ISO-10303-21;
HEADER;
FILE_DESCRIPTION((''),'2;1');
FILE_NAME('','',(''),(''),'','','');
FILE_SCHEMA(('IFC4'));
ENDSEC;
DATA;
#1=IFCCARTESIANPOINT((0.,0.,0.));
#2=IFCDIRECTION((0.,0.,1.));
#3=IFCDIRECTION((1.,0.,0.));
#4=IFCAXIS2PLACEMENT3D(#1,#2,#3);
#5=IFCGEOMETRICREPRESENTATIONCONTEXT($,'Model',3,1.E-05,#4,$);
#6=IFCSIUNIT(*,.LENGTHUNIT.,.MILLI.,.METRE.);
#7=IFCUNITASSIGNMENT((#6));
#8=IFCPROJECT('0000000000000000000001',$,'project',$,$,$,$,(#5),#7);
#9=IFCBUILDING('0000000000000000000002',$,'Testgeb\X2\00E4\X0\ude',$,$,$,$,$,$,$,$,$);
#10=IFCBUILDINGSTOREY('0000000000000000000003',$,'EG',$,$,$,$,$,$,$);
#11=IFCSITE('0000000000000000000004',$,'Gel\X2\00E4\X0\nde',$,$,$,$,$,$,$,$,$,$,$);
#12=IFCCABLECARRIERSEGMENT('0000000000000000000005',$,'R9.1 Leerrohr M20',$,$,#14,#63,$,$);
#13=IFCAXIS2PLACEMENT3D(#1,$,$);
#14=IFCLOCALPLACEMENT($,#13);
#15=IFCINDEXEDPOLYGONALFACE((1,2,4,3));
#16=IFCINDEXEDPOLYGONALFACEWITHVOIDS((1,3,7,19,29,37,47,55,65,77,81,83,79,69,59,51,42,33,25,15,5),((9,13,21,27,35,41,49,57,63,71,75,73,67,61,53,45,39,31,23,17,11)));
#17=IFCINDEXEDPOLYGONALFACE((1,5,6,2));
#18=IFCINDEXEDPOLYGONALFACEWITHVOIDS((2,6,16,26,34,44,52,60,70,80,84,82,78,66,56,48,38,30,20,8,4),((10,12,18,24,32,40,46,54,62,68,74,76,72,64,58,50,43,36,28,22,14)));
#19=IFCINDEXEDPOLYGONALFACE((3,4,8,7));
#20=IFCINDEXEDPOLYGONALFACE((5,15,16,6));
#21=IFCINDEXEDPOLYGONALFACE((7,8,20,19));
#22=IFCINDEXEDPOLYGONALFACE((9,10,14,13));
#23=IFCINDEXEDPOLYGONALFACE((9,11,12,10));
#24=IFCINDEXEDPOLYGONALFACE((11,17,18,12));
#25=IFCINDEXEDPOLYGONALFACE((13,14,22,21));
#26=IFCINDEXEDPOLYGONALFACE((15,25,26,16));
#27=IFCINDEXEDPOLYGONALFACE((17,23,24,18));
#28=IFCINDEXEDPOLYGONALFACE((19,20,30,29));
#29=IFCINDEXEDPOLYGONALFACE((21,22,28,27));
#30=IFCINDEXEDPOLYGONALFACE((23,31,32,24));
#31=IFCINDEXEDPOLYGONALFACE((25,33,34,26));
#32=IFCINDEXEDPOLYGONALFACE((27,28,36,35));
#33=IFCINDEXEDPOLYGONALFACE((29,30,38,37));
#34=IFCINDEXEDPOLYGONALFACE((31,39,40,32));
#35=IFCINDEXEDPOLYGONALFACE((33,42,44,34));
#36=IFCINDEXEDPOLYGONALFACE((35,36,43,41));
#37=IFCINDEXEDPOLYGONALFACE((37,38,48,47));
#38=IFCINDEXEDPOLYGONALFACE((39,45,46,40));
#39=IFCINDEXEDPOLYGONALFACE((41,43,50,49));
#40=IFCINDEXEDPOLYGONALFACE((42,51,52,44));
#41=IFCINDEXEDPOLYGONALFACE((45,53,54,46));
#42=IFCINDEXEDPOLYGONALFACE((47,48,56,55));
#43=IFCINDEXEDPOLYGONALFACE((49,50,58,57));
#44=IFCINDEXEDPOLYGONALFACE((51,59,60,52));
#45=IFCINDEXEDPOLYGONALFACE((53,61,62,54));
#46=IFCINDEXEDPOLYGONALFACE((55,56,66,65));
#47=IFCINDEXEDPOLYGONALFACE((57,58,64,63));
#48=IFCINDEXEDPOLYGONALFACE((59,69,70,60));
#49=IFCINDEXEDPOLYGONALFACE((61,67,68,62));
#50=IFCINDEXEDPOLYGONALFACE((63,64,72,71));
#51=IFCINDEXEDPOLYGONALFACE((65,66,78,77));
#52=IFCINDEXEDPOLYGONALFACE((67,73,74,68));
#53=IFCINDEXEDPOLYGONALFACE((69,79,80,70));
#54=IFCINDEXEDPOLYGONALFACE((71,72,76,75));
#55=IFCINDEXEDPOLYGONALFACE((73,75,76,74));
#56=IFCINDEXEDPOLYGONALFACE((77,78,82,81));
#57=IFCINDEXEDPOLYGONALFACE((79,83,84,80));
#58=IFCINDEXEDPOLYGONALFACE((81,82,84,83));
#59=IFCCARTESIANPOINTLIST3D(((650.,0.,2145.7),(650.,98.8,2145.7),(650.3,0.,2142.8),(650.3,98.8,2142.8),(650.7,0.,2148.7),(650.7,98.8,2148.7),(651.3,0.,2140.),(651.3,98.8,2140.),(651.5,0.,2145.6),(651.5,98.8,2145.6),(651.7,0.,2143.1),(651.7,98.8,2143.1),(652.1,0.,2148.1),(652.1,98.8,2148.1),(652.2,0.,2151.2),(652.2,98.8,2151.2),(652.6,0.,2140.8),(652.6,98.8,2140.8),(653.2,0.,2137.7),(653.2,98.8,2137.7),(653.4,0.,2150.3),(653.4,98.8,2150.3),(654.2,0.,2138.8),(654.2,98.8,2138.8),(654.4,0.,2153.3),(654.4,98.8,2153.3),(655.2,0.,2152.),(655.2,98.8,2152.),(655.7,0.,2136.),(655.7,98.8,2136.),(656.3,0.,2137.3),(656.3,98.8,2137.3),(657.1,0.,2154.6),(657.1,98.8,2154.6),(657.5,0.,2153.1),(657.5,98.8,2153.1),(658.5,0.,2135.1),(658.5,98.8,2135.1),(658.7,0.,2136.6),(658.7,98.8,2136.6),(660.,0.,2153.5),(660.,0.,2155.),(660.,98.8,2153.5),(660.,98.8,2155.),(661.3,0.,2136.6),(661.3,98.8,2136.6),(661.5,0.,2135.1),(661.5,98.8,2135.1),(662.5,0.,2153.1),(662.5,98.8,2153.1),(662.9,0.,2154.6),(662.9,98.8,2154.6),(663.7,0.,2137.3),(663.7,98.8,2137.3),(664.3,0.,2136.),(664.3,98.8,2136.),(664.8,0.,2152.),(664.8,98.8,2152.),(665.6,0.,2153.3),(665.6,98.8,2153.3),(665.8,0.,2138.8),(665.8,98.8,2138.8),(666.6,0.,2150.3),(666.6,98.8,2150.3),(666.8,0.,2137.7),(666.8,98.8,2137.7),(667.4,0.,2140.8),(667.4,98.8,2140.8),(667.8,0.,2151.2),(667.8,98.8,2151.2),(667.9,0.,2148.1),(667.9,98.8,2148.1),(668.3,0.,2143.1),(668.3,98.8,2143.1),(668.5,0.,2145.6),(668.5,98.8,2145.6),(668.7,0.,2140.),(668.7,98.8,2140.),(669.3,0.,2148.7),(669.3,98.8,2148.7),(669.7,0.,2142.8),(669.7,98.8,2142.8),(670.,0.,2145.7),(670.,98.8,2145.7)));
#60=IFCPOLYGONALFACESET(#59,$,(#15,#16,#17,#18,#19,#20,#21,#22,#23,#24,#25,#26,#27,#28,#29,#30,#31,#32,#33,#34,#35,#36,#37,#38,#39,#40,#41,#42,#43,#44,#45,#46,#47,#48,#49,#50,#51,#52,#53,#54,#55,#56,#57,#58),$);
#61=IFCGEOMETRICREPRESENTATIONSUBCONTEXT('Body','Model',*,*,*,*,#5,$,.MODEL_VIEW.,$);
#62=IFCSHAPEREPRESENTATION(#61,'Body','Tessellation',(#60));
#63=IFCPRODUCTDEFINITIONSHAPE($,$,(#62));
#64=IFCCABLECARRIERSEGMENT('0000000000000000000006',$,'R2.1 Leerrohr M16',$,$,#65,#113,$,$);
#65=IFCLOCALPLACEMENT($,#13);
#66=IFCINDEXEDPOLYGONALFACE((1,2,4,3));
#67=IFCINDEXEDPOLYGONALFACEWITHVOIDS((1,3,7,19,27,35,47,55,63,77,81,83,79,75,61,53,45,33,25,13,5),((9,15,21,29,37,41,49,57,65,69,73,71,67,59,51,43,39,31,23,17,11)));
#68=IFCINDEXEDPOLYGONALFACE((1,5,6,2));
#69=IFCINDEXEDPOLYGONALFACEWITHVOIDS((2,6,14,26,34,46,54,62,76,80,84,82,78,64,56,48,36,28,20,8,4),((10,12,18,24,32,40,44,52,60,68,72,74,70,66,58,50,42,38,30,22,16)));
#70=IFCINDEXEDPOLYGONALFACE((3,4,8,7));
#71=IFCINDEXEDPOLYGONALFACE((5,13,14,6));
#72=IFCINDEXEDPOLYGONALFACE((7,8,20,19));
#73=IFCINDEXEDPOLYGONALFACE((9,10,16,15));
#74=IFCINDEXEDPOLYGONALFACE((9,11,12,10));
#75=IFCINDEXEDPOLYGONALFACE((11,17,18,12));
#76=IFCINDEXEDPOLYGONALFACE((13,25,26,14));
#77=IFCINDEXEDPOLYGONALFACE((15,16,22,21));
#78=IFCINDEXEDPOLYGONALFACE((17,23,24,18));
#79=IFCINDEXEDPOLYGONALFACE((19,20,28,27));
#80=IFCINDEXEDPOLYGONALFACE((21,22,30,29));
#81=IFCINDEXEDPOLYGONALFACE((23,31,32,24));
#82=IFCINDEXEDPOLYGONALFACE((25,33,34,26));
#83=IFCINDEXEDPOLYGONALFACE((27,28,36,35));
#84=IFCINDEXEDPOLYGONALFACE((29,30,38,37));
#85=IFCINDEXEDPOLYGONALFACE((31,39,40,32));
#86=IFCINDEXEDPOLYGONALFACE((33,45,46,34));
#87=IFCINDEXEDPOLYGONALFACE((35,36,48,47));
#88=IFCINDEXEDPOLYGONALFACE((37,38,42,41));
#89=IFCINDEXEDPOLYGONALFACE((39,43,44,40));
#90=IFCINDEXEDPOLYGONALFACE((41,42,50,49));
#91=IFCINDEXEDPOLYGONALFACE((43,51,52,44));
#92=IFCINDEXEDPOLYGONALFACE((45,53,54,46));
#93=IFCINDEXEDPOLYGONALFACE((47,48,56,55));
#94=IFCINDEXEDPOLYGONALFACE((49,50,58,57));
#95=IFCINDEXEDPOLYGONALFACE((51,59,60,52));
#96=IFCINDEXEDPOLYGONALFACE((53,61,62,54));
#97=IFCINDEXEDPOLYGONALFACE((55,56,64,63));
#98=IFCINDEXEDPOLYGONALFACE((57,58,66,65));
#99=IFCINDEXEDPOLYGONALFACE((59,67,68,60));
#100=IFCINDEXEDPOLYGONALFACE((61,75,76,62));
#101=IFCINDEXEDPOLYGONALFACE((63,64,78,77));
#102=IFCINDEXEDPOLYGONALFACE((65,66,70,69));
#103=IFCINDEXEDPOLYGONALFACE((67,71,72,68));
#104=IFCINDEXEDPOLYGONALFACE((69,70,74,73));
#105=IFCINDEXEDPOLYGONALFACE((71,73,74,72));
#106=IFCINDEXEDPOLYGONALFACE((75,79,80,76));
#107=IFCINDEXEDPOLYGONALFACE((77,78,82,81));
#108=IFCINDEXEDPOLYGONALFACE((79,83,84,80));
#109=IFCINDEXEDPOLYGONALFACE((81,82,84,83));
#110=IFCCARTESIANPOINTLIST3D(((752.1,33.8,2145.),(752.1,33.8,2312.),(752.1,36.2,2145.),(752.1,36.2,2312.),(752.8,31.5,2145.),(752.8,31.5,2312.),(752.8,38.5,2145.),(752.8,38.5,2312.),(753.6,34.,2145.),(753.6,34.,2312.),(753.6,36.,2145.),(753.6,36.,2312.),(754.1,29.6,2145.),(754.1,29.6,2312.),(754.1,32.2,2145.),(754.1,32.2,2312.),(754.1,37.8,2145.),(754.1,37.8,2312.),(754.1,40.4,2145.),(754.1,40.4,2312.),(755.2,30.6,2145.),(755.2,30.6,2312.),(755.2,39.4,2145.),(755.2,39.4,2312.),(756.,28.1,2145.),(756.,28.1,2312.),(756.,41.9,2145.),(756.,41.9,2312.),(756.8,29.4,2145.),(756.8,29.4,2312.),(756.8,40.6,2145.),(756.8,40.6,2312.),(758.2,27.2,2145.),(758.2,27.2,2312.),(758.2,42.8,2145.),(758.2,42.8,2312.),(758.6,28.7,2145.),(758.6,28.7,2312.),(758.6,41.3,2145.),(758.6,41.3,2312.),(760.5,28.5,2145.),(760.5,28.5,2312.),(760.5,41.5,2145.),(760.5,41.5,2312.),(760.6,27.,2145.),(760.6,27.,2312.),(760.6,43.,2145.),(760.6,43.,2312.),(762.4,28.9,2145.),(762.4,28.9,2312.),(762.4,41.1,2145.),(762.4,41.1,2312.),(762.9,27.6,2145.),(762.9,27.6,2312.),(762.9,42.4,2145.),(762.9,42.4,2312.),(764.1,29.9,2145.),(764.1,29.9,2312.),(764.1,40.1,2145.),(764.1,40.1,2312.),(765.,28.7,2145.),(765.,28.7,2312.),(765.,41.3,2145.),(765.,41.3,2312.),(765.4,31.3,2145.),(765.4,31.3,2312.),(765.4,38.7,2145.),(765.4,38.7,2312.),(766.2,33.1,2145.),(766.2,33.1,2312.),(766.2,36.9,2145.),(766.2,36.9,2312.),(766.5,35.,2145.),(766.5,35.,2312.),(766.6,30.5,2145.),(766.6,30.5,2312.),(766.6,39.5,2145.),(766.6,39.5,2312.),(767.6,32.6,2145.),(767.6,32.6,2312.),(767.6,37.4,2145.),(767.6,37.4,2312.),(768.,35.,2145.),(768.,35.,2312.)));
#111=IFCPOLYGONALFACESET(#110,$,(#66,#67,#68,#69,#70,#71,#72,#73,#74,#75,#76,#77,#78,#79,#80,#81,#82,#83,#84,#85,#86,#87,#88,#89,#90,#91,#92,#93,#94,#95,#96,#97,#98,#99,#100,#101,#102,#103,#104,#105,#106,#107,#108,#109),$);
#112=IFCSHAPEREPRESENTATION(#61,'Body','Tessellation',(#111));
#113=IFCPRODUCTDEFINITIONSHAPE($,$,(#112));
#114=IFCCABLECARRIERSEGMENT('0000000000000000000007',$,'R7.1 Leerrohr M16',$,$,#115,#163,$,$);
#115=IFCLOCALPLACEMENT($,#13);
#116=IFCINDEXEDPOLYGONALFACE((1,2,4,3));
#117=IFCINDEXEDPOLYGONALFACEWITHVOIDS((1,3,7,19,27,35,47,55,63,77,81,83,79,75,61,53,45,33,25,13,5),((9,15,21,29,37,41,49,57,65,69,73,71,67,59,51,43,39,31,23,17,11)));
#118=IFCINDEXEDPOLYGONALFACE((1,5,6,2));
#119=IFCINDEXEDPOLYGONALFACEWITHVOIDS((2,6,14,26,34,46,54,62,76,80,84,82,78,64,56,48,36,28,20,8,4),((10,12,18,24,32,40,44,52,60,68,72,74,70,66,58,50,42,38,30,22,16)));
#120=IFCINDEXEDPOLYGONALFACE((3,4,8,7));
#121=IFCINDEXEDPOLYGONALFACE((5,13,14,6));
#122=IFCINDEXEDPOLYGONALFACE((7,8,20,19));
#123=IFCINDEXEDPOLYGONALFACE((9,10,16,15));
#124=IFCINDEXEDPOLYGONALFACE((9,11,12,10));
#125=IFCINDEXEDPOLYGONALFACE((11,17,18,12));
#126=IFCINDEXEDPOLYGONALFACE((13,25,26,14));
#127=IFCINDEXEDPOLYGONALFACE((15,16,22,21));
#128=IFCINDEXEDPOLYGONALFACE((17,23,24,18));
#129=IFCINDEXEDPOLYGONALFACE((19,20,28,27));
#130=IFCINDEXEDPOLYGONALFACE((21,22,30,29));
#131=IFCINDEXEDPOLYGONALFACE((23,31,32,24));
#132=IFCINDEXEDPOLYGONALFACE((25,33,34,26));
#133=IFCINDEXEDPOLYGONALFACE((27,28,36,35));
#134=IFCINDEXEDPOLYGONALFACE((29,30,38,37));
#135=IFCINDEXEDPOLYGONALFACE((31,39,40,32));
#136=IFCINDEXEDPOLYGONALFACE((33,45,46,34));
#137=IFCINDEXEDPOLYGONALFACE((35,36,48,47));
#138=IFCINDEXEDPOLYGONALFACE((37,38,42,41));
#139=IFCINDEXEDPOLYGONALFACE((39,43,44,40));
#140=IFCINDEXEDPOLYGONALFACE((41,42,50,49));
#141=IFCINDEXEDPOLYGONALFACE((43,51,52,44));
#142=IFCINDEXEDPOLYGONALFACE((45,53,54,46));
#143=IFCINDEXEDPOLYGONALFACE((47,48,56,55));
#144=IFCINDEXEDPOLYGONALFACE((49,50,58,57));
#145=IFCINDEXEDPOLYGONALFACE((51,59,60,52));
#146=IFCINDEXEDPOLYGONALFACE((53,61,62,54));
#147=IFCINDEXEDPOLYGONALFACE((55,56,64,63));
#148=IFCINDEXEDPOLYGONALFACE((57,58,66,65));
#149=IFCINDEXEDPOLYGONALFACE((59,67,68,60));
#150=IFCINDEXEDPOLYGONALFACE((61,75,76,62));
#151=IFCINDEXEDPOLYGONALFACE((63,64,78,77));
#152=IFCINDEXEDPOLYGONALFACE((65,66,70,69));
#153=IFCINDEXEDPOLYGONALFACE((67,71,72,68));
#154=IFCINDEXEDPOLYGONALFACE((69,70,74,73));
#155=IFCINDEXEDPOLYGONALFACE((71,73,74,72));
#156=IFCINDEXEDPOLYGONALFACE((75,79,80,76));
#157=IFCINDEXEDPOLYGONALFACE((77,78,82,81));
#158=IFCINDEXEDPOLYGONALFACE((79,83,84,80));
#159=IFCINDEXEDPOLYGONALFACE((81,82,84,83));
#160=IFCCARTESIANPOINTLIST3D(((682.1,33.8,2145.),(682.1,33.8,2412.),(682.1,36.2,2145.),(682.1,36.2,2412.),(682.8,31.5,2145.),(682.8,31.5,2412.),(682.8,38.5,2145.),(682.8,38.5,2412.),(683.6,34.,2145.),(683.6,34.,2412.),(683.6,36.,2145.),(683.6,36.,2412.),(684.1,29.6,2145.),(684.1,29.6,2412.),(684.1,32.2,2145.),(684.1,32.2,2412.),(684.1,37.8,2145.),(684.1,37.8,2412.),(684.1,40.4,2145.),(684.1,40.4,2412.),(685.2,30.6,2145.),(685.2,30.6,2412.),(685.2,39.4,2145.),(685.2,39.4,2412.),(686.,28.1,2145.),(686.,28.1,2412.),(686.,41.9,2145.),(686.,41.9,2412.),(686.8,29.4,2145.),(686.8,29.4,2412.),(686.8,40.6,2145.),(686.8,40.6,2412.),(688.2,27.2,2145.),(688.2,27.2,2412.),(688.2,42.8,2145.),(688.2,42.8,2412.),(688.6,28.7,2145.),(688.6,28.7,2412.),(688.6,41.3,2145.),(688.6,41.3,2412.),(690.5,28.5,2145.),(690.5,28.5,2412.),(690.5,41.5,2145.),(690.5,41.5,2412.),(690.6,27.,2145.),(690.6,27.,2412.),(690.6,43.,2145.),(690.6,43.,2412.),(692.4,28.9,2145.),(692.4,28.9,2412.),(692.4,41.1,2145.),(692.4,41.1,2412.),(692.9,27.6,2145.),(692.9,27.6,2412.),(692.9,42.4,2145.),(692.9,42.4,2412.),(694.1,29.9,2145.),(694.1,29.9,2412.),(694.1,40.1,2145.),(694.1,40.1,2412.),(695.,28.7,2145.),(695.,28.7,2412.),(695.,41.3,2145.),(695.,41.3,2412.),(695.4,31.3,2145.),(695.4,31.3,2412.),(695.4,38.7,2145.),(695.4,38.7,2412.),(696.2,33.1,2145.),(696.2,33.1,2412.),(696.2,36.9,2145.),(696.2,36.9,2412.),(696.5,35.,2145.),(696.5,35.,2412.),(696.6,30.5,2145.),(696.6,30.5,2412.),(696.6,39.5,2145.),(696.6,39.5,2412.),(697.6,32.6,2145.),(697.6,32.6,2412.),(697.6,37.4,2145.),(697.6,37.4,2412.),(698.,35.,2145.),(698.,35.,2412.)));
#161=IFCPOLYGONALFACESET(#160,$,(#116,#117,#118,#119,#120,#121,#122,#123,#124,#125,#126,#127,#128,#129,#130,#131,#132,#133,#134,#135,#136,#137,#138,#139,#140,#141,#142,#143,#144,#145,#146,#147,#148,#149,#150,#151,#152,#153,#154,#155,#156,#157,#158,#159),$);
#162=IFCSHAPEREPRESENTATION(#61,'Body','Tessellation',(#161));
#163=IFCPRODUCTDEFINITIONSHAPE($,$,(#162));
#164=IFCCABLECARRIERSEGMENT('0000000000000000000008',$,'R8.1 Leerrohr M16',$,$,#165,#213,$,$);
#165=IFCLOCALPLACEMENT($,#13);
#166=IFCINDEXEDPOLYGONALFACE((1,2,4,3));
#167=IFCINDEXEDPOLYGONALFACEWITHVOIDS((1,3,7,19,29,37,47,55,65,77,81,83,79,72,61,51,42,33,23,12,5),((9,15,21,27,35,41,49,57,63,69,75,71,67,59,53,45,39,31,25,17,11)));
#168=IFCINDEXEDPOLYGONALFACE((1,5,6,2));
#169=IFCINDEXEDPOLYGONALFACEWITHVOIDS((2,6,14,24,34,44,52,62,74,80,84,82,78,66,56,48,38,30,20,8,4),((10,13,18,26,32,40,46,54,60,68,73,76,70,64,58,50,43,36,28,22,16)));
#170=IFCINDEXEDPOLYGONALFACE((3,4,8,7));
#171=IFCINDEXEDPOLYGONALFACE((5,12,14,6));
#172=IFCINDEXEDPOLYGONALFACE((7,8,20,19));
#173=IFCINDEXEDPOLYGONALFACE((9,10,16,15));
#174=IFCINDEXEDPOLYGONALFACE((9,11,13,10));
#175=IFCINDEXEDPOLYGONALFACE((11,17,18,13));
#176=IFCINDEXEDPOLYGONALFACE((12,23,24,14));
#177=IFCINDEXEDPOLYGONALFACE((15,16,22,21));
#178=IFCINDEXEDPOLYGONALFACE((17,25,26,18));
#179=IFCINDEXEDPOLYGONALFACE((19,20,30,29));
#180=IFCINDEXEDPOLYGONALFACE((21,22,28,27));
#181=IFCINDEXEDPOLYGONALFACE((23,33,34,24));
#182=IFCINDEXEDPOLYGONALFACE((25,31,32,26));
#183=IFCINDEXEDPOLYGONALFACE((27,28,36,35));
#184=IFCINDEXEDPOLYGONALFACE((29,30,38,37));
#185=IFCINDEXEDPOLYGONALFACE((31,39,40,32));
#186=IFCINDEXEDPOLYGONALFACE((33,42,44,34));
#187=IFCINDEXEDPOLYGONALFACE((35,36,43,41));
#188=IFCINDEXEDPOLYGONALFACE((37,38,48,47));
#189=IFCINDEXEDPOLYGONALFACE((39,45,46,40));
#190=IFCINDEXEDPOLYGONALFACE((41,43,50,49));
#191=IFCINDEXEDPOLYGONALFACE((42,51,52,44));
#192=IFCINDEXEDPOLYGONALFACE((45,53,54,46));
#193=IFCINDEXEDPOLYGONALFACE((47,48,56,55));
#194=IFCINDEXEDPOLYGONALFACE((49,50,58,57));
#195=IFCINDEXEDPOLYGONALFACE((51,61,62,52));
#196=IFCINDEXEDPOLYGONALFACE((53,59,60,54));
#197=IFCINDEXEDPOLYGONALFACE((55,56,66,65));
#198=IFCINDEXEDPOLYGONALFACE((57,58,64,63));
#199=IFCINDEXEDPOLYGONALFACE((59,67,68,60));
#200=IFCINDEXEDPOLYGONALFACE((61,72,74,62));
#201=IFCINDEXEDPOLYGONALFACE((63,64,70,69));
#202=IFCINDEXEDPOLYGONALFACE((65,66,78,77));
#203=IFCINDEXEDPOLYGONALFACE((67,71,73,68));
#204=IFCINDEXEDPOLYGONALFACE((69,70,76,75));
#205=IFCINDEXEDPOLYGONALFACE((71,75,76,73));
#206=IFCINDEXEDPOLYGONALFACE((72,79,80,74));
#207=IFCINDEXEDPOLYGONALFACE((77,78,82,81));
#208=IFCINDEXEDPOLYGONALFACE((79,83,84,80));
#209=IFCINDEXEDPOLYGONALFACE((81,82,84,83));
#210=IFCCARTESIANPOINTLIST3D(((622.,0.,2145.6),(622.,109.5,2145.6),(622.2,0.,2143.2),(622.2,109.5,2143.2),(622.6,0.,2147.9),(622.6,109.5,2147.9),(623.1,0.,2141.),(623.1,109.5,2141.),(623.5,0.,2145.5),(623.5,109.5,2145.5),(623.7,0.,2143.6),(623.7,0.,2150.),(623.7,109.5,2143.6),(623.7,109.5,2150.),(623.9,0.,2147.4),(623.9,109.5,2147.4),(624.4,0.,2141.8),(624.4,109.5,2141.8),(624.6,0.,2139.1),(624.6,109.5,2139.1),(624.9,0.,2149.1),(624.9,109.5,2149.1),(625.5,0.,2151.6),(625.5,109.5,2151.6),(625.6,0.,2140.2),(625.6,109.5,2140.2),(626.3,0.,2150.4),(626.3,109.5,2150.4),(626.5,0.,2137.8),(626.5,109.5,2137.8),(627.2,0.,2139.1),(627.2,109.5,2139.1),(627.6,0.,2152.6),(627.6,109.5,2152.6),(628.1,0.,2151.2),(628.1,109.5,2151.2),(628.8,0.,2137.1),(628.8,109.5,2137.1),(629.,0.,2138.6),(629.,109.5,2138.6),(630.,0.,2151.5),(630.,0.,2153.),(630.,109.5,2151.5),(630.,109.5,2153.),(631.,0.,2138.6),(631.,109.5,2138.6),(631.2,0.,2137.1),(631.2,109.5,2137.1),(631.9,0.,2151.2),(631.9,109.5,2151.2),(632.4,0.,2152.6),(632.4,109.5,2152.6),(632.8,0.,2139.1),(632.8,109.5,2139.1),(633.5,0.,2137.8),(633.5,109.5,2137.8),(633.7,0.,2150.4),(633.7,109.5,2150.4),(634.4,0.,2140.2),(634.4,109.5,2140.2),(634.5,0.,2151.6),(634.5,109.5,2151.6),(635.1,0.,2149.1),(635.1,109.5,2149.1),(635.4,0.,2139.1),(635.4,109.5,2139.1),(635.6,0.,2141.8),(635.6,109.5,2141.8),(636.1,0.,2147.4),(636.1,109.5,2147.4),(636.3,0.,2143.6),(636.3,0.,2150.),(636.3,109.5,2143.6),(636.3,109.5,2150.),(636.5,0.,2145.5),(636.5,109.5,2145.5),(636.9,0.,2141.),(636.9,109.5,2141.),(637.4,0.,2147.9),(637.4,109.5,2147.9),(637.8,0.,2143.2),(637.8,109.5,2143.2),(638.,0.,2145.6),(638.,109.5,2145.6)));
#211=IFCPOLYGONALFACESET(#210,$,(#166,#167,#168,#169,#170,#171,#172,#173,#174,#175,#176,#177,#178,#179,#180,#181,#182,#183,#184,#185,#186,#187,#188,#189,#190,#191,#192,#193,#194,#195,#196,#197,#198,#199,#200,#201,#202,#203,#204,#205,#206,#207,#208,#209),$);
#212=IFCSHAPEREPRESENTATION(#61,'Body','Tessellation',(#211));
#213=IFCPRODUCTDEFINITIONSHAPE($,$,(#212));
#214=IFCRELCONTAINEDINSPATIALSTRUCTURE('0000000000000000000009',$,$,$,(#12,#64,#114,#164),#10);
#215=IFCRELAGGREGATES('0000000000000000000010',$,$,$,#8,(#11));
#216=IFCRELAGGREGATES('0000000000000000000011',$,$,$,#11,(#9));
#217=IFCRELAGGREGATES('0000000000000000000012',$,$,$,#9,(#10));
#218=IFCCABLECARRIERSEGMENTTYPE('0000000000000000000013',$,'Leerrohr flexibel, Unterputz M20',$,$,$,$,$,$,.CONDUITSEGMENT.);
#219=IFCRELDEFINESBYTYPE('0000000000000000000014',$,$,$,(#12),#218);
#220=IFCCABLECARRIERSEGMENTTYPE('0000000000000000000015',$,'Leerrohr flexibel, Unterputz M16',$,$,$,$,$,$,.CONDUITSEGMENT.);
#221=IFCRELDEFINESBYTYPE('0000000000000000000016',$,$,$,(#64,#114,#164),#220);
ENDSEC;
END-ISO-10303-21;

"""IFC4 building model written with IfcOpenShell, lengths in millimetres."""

from ifc_helpers import new_model, si_unit, frame, origin_with_axes, place, context, subcontext, project, spatial, hollow_circle, extrude, type_object, element, save


model = new_model("IFC4")

# Units and contexts
model_context = context("Model", 3, precision=1e-05, world=origin_with_axes())
body_context = subcontext(model_context, "Body", "Model", "MODEL_VIEW")
ifc_project = project(units=[si_unit("LENGTHUNIT", "METRE", prefix="MILLI")], contexts=[model_context])

# Site, building, storey
site = spatial("IfcSite", under=ifc_project, Name="Gelände")
building = spatial("IfcBuilding", under=site, Name="Testgebäude")
storey = spatial("IfcBuildingStorey", under=building, Name="EG")

# Cable carrier segment
cable_carrier_segment_type_1 = type_object("IfcCableCarrierSegmentType", Name="Leerrohr flexibel, Unterputz M20", PredefinedType="CONDUITSEGMENT")
cable_carrier_segment_1_placement = place(None, frame((660.0, 0.0, 2145.0), z_axis=(0.0, 1.0, 0.0), x_axis=(0.0, 0.0, 1.0)))
element("IfcCableCarrierSegment", 1, at=cable_carrier_segment_1_placement, inside=storey, type_object=cable_carrier_segment_type_1, Name="R9.1 Leerrohr M20", context=body_context, shape_type="SweptSolid", body=[
    extrude(hollow_circle(Radius=10.0, WallThickness=1.5), None, (0.0, 0.0, 1.0), 98.8),
])

# Cable carrier segments
cable_carrier_segment_type_2 = type_object("IfcCableCarrierSegmentType", Name="Leerrohr flexibel, Unterputz M16", PredefinedType="CONDUITSEGMENT")
cable_carrier_segment_2_placement = place(None, frame((760.0, 35.0, 2145.0), z_axis=(0.0, 0.0, 1.0), x_axis=(1.0, 0.0, 0.0)))
element("IfcCableCarrierSegment", 2, at=cable_carrier_segment_2_placement, inside=storey, type_object=cable_carrier_segment_type_2, Name="R2.1 Leerrohr M16", context=body_context, shape_type="SweptSolid", body=[
    extrude(hollow_circle(Radius=8.0, WallThickness=1.5), None, (0.0, 0.0, 1.0), 167.0),
])
cable_carrier_segment_3_placement = place(None, frame((690.0, 35.0, 2145.0), z_axis=(0.0, 0.0, 1.0), x_axis=(1.0, 0.0, 0.0)))
element("IfcCableCarrierSegment", 3, at=cable_carrier_segment_3_placement, inside=storey, type_object=cable_carrier_segment_type_2, Name="R7.1 Leerrohr M16", context=body_context, shape_type="SweptSolid", body=[
    extrude(hollow_circle(Radius=8.0, WallThickness=1.5), None, (0.0, 0.0, 1.0), 267.0),
])
cable_carrier_segment_4_placement = place(None, frame((630.0, 0.0, 2145.0), z_axis=(0.0, 1.0, 0.0), x_axis=(0.0, 0.0, 1.0)))
element("IfcCableCarrierSegment", 4, at=cable_carrier_segment_4_placement, inside=storey, type_object=cable_carrier_segment_type_2, Name="R8.1 Leerrohr M16", context=body_context, shape_type="SweptSolid", body=[
    extrude(hollow_circle(Radius=8.0, WallThickness=1.5), None, (0.0, 0.0, 1.0), 109.5),
])

save(model, "model.ifc")
